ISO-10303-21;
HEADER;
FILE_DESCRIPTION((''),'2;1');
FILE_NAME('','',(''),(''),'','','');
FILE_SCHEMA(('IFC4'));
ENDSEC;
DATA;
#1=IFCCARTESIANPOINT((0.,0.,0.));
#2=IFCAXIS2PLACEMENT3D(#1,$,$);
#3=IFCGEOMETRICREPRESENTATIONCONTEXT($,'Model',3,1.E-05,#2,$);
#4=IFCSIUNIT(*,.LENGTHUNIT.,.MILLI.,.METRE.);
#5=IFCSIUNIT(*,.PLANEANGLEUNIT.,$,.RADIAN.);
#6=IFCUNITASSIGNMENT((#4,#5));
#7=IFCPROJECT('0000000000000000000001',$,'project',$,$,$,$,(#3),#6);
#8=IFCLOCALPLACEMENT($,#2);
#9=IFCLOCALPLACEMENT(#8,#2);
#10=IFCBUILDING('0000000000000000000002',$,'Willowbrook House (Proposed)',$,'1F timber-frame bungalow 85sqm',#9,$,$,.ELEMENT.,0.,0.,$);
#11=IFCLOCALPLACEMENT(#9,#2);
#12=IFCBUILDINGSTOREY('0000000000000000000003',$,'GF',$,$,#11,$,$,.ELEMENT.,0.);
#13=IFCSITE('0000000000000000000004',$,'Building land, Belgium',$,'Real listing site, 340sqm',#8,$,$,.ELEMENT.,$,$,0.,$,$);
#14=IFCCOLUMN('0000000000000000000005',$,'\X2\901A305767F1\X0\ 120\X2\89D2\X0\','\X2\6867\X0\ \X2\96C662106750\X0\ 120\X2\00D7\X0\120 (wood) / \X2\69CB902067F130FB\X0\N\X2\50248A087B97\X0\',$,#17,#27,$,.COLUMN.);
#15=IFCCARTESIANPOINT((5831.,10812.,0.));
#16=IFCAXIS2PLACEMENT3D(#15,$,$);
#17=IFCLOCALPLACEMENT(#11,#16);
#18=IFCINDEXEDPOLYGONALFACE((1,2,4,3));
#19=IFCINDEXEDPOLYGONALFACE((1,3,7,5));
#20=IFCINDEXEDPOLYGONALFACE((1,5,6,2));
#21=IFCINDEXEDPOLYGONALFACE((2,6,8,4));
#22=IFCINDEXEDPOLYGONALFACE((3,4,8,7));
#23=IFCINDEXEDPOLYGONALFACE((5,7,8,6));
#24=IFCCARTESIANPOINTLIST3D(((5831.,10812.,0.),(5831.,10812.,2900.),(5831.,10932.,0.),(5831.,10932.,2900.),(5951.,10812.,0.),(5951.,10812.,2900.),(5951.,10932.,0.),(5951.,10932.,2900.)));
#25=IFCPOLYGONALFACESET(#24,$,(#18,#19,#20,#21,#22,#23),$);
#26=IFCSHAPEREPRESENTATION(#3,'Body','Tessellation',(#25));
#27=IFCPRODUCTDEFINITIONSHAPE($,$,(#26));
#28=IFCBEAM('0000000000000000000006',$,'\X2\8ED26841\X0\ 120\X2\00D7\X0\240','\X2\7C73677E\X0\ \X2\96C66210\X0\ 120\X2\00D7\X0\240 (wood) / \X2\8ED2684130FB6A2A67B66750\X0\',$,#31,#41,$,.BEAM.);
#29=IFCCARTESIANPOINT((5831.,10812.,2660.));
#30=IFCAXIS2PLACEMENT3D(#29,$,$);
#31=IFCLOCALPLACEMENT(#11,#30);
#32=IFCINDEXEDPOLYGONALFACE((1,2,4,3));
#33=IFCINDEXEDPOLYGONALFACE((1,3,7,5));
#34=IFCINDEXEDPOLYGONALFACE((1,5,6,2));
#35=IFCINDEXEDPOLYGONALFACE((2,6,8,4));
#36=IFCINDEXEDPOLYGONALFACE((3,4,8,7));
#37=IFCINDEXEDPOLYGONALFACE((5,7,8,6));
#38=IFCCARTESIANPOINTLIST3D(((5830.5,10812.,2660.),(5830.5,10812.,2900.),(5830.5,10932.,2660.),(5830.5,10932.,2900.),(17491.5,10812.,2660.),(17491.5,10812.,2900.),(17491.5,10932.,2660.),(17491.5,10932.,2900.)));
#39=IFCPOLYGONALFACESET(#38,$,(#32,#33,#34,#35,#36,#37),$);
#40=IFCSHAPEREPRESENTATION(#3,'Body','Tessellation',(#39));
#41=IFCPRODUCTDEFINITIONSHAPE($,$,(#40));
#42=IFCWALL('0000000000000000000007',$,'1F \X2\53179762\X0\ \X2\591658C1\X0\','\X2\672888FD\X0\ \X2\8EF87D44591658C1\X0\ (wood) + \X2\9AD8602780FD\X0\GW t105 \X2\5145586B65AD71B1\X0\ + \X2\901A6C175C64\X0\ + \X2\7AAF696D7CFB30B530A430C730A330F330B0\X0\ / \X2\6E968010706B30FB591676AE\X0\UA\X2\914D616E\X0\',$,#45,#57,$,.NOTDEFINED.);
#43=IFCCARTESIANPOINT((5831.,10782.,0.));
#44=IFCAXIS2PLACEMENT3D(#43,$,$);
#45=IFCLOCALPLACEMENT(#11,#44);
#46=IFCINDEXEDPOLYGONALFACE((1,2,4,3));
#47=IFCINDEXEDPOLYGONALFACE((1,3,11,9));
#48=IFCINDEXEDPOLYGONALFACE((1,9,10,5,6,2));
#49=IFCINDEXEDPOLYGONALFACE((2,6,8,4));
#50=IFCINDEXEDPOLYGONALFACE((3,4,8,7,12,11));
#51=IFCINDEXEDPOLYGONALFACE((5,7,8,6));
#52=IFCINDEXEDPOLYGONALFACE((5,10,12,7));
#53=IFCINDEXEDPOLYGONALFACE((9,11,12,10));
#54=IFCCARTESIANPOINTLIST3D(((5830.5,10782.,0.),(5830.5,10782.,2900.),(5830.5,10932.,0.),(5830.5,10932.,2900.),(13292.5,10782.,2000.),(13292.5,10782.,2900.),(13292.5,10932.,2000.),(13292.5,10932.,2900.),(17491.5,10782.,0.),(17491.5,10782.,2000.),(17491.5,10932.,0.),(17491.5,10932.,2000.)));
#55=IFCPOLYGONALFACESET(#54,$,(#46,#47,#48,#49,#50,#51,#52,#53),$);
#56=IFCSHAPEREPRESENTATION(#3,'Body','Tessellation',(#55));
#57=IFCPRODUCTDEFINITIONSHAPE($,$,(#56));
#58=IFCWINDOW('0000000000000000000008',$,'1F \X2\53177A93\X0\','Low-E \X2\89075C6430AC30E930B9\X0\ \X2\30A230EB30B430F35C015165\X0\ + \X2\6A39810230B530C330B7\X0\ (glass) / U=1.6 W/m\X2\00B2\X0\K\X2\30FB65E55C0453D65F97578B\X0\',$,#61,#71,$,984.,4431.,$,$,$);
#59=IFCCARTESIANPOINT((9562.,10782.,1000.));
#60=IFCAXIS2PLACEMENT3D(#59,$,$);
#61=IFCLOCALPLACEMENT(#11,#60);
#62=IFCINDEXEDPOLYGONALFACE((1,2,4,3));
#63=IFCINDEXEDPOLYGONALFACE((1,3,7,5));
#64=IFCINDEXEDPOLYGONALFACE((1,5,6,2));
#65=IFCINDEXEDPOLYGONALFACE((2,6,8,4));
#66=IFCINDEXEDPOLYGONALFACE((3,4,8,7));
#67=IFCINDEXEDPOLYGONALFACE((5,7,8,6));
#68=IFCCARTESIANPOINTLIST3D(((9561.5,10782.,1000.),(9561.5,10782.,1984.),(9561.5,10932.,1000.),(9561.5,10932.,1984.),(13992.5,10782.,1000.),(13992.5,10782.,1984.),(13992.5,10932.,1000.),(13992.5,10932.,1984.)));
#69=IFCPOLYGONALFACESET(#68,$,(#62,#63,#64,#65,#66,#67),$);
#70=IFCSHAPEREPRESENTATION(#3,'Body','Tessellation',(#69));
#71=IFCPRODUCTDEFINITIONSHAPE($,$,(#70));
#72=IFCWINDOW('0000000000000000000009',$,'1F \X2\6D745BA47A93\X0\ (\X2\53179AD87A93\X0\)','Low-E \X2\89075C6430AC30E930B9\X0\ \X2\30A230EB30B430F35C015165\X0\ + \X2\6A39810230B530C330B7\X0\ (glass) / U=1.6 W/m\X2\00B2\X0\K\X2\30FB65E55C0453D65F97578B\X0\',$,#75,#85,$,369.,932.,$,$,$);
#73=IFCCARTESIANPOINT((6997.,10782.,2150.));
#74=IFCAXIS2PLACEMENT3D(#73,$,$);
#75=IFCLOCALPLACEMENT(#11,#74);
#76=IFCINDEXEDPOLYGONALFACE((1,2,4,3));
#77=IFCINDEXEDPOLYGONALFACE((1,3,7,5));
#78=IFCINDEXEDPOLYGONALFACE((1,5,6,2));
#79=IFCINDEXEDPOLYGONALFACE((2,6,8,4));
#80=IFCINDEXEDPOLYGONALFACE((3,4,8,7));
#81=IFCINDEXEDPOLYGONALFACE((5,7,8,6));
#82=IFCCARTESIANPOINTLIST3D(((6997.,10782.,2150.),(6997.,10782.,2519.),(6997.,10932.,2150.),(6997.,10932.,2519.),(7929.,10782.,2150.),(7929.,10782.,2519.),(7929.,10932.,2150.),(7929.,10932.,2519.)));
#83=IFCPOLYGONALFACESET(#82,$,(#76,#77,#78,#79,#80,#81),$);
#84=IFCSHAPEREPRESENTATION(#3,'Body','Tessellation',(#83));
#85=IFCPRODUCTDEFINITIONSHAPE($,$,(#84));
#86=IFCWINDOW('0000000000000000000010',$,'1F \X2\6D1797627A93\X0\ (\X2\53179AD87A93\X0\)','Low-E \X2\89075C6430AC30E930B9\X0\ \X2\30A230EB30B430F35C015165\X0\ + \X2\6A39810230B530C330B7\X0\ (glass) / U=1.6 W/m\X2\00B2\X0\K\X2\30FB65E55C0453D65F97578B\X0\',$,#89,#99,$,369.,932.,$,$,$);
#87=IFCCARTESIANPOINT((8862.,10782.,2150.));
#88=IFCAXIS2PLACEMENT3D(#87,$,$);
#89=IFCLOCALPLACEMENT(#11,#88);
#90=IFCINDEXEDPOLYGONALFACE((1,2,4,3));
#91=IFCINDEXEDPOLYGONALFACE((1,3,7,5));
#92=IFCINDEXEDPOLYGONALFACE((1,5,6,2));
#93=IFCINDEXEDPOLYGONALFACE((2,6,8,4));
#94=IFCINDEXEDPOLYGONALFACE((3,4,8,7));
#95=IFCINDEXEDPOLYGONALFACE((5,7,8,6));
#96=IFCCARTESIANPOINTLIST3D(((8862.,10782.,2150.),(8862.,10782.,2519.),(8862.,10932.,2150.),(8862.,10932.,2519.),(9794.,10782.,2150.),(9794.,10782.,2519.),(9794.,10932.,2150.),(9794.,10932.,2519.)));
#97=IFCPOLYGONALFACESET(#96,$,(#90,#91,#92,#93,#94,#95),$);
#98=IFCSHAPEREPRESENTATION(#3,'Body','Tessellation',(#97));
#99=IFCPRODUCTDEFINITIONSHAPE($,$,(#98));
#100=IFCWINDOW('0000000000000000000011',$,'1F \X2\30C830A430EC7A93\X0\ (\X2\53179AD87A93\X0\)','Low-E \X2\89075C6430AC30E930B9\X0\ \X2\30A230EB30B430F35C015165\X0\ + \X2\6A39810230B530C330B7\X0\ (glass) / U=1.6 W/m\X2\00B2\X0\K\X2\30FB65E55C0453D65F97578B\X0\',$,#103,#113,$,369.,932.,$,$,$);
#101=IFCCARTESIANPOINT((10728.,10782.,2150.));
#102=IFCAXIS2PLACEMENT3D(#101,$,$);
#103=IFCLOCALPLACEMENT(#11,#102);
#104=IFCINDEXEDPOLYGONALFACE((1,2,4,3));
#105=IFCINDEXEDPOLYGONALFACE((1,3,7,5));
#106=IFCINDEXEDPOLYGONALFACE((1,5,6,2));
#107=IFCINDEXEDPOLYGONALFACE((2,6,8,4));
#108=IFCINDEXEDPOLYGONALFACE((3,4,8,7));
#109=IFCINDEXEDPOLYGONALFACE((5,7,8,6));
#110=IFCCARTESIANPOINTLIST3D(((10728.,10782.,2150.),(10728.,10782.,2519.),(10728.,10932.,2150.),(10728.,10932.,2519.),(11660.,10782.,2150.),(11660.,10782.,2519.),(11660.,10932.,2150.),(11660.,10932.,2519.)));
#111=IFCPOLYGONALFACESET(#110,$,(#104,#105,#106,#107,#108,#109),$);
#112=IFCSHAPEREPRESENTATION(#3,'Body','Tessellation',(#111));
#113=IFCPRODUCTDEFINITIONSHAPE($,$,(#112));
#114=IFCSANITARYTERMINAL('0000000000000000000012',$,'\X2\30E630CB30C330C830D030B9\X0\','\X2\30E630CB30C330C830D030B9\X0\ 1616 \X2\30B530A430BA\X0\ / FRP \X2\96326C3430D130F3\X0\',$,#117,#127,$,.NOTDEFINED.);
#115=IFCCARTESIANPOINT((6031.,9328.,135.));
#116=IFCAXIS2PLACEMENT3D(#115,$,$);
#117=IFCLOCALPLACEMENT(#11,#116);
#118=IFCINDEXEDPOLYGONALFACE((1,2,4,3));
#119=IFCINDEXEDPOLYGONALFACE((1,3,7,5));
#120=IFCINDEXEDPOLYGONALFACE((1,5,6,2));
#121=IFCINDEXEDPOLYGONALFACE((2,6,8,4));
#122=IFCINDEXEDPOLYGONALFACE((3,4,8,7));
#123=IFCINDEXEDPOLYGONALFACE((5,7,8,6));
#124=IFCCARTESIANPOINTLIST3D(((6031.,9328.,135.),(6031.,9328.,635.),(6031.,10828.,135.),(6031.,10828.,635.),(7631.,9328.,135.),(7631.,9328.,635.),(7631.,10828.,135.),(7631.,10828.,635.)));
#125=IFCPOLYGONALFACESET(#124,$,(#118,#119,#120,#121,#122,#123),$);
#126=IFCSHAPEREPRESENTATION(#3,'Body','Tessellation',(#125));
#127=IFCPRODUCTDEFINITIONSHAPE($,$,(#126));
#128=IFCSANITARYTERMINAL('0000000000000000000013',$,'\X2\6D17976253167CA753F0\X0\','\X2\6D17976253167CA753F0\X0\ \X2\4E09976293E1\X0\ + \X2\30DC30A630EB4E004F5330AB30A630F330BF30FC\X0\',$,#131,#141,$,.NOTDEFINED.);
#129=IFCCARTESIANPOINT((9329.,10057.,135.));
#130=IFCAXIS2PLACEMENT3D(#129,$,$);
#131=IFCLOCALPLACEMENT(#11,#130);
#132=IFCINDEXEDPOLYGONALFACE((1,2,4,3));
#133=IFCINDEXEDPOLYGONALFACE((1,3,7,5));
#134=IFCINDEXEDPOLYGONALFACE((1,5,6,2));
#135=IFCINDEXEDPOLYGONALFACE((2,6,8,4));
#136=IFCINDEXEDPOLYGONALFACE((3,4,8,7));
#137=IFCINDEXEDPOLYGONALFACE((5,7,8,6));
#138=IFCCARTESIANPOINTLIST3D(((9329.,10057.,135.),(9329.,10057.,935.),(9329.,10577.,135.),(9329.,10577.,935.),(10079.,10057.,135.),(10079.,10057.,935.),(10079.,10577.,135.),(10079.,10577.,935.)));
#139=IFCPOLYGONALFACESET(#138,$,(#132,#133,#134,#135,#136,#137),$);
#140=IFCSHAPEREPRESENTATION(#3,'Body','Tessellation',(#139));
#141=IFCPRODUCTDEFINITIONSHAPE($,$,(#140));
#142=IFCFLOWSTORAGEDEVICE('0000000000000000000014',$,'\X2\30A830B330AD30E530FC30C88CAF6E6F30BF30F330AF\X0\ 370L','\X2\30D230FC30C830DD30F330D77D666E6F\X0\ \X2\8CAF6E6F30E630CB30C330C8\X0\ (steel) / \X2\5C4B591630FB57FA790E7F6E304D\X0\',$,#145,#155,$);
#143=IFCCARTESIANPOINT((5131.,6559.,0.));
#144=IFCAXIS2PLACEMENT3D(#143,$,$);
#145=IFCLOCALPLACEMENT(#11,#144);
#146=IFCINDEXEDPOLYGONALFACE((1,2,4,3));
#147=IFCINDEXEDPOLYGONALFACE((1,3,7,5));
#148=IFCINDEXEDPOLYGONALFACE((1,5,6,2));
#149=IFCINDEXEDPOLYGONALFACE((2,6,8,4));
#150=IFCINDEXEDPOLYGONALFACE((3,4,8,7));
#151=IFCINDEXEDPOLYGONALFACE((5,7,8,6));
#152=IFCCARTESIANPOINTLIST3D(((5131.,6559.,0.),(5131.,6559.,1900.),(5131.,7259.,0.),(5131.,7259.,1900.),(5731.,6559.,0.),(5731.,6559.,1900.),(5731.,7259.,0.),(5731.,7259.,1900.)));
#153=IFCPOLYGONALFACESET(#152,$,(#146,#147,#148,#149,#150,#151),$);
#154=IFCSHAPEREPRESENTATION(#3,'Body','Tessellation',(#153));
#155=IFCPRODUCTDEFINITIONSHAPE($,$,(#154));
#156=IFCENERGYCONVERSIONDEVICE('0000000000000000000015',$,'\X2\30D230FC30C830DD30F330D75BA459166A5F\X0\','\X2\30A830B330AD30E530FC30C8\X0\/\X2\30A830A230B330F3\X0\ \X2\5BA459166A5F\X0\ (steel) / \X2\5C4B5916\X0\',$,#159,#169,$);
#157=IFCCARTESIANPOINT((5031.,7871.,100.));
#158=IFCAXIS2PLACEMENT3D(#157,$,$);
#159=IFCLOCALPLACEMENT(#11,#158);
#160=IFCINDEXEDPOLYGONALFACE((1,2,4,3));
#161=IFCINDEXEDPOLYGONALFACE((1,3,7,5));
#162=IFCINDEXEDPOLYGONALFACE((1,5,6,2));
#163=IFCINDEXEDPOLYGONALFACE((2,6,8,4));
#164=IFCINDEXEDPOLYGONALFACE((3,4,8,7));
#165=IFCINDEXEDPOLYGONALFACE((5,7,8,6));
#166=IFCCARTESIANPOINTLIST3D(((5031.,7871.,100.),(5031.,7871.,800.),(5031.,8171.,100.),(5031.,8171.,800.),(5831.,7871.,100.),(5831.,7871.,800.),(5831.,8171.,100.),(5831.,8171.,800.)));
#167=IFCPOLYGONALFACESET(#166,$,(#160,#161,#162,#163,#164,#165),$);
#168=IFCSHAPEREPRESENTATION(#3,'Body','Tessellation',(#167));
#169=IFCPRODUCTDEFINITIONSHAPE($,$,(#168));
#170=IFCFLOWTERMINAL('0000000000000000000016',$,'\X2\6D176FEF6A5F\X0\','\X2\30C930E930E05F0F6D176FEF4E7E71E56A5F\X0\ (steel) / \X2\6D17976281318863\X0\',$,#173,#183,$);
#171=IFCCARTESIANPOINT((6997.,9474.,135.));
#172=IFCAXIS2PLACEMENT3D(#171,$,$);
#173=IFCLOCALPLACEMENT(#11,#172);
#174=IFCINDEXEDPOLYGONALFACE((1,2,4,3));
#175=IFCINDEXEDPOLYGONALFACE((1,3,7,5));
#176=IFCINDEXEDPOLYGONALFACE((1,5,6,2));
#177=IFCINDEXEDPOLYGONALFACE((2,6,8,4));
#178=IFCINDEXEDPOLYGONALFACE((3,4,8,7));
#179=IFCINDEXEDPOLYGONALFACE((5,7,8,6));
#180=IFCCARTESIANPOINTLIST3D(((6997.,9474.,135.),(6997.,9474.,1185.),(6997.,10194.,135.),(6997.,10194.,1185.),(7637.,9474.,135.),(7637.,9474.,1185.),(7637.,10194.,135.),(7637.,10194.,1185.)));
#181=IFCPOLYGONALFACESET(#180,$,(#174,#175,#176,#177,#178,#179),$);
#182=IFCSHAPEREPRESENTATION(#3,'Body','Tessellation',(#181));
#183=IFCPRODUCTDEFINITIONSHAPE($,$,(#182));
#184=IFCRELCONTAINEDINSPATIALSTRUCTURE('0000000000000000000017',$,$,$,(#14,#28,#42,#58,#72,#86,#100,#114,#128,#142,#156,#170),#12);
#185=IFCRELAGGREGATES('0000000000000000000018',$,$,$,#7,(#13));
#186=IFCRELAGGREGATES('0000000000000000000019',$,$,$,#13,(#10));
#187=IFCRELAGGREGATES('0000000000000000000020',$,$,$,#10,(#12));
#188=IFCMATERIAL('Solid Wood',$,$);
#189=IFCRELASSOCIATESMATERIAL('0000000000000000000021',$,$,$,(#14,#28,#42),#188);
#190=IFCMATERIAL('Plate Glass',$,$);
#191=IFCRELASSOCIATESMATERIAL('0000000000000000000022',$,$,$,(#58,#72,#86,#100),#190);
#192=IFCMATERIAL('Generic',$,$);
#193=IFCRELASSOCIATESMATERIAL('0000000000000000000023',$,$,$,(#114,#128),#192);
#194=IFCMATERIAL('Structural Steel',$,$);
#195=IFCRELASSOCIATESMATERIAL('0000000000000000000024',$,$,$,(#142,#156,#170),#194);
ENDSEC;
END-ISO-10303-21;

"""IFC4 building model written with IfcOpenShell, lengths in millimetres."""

from ifc_helpers import new_model, si_unit, frame, frame_2d, origin, place, context, project, spatial, rectangle, extrude, material, element, fill, save


model = new_model("IFC4")

# Units and contexts
model_context = context("Model", 3, precision=1e-05, world=origin())
ifc_project = project(units=[si_unit("LENGTHUNIT", "METRE", prefix="MILLI"), si_unit("PLANEANGLEUNIT", "RADIAN")], contexts=[model_context])

# Site, building, storey
site_placement = place(None, origin())
site = spatial("IfcSite", under=ifc_project, at=site_placement, Name="Building land, Belgium", ObjectType="Real listing site, 340sqm", CompositionType="ELEMENT", RefElevation=0.0)
building_placement = place(site_placement, origin())
building = spatial("IfcBuilding", under=site, at=building_placement, Name="Willowbrook House (Proposed)", ObjectType="1F timber-frame bungalow 85sqm", CompositionType="ELEMENT", ElevationOfRefHeight=0.0, ElevationOfTerrain=0.0)
storey_placement = place(building_placement, origin())
storey = spatial("IfcBuildingStorey", under=building, at=storey_placement, Name="GF", CompositionType="ELEMENT", Elevation=0.0)

# Column
ifc_material_1 = material(Name="Solid Wood")
column_1_placement = place(storey_placement, frame((5831.0, 10812.0, 0.0)))
element("IfcColumn", 1, at=column_1_placement, inside=storey, material=ifc_material_1, Name="通し柱 120角", Description="桧 集成材 120×120 (wood) / 構造柱・N値計算", PredefinedType="COLUMN", context=model_context, shape_type="SweptSolid", body=[
    extrude(rectangle(XDim=120.0, YDim=120.0, at=frame_2d((60.0, 60.0))), frame((5831.0, 10812.0, 0.0)), (0.0, 0.0, 1.0), 2900.0),
])

# Beam
beam_1_placement = place(storey_placement, frame((5831.0, 10812.0, 2660.0)))
element("IfcBeam", 2, at=beam_1_placement, inside=storey, material=ifc_material_1, Name="軒桁 120×240", Description="米松 集成 120×240 (wood) / 軒桁・横架材", PredefinedType="BEAM", context=model_context, shape_type="SweptSolid", body=[
    extrude(rectangle(XDim=11661.0, YDim=120.0, at=frame_2d((5830.0, 60.0))), frame((5831.0, 10812.0, 2660.0)), (0.0, 0.0, 1.0), 240.0),
])

# Wall, openings, windows
wall_1_placement = place(storey_placement, frame((5831.0, 10782.0, 0.0)))
wall_1 = element("IfcWall", 3, at=wall_1_placement, inside=storey, material=ifc_material_1, Name="1F 北面 外壁", Description="木製 軸組外壁 (wood) + 高性能GW t105 充填断熱 + 通気層 + 窯業系サイディング / 準耐火・外皮UA配慮", PredefinedType="NOTDEFINED", context=model_context, shape_type="SweptSolid", body=[
    extrude(rectangle(XDim=11661.0, YDim=150.0, at=frame_2d((5830.0, 75.0))), frame((5831.0, 10782.0, 0.0)), (0.0, 0.0, 1.0), 2900.0),
])
opening_1_placement = place(storey_placement, frame((9562.0, 10782.0, 1000.0)))
opening_1 = element("IfcOpeningElement", 4, at=opening_1_placement, cuts=wall_1, PredefinedType="NOTDEFINED", context=model_context, shape_type="SweptSolid", body=[
    extrude(rectangle(XDim=4431.0, YDim=150.0, at=frame_2d((2215.0, 75.0))), frame((9562.0, 10782.0, 1000.0)), (0.0, 0.0, 1.0), 984.0),
])
opening_2_placement = place(storey_placement, frame((6997.0, 10782.0, 2150.0)))
opening_2 = element("IfcOpeningElement", 5, at=opening_2_placement, cuts=wall_1, PredefinedType="NOTDEFINED", context=model_context, shape_type="SweptSolid", body=[
    extrude(rectangle(XDim=932.0, YDim=150.0, at=frame_2d((466.0, 75.0))), frame((6997.0, 10782.0, 2150.0)), (0.0, 0.0, 1.0), 369.0),
])
opening_3_placement = place(storey_placement, frame((8862.0, 10782.0, 2150.0)))
opening_3 = element("IfcOpeningElement", 6, at=opening_3_placement, cuts=wall_1, PredefinedType="NOTDEFINED", context=model_context, shape_type="SweptSolid", body=[
    extrude(rectangle(XDim=932.0, YDim=150.0, at=frame_2d((466.0, 75.0))), frame((8862.0, 10782.0, 2150.0)), (0.0, 0.0, 1.0), 369.0),
])
opening_4_placement = place(storey_placement, frame((10728.0, 10782.0, 2150.0)))
opening_4 = element("IfcOpeningElement", 7, at=opening_4_placement, cuts=wall_1, PredefinedType="NOTDEFINED", context=model_context, shape_type="SweptSolid", body=[
    extrude(rectangle(XDim=932.0, YDim=150.0, at=frame_2d((466.0, 75.0))), frame((10728.0, 10782.0, 2150.0)), (0.0, 0.0, 1.0), 369.0),
])
ifc_material_2 = material(Name="Plate Glass")
window_1_placement = place(storey_placement, frame((9562.0, 10782.0, 1000.0)))
window_1 = element("IfcWindow", 8, at=window_1_placement, inside=storey, material=ifc_material_2, Name="1F 北窓", Description="Low-E 複層ガラス アルゴン封入 + 樹脂サッシ (glass) / U=1.6 W/m²K・日射取得型", OverallHeight=984.0, OverallWidth=4431.0, context=model_context, shape_type="SweptSolid", body=[
    extrude(rectangle(XDim=4431.0, YDim=150.0, at=frame_2d((2215.0, 75.0))), frame((9562.0, 10782.0, 1000.0)), (0.0, 0.0, 1.0), 984.0),
])
fill(opening_1, window_1)
window_2_placement = place(storey_placement, frame((6997.0, 10782.0, 2150.0)))
window_2 = element("IfcWindow", 9, at=window_2_placement, inside=storey, material=ifc_material_2, Name="1F 浴室窓 (北高窓)", Description="Low-E 複層ガラス アルゴン封入 + 樹脂サッシ (glass) / U=1.6 W/m²K・日射取得型", OverallHeight=369.0, OverallWidth=932.0, context=model_context, shape_type="SweptSolid", body=[
    extrude(rectangle(XDim=932.0, YDim=150.0, at=frame_2d((466.0, 75.0))), frame((6997.0, 10782.0, 2150.0)), (0.0, 0.0, 1.0), 369.0),
])
fill(opening_2, window_2)
window_3_placement = place(storey_placement, frame((8862.0, 10782.0, 2150.0)))
window_3 = element("IfcWindow", 10, at=window_3_placement, inside=storey, material=ifc_material_2, Name="1F 洗面窓 (北高窓)", Description="Low-E 複層ガラス アルゴン封入 + 樹脂サッシ (glass) / U=1.6 W/m²K・日射取得型", OverallHeight=369.0, OverallWidth=932.0, context=model_context, shape_type="SweptSolid", body=[
    extrude(rectangle(XDim=932.0, YDim=150.0, at=frame_2d((466.0, 75.0))), frame((8862.0, 10782.0, 2150.0)), (0.0, 0.0, 1.0), 369.0),
])
fill(opening_3, window_3)
window_4_placement = place(storey_placement, frame((10728.0, 10782.0, 2150.0)))
window_4 = element("IfcWindow", 11, at=window_4_placement, inside=storey, material=ifc_material_2, Name="1F トイレ窓 (北高窓)", Description="Low-E 複層ガラス アルゴン封入 + 樹脂サッシ (glass) / U=1.6 W/m²K・日射取得型", OverallHeight=369.0, OverallWidth=932.0, context=model_context, shape_type="SweptSolid", body=[
    extrude(rectangle(XDim=932.0, YDim=150.0, at=frame_2d((466.0, 75.0))), frame((10728.0, 10782.0, 2150.0)), (0.0, 0.0, 1.0), 369.0),
])
fill(opening_4, window_4)

# Sanitary terminals
ifc_material_3 = material(Name="Generic")
sanitary_terminal_1_placement = place(storey_placement, frame((6031.0, 9328.0, 135.0)))
element("IfcSanitaryTerminal", 12, at=sanitary_terminal_1_placement, inside=storey, material=ifc_material_3, Name="ユニットバス", Description="ユニットバス 1616 サイズ / FRP 防水パン", PredefinedType="NOTDEFINED", context=model_context, shape_type="SweptSolid", body=[
    extrude(rectangle(XDim=1600.0, YDim=1500.0, at=frame_2d((800.0, 750.0))), frame((6031.0, 9328.0, 135.0)), (0.0, 0.0, 1.0), 500.0),
])
sanitary_terminal_2_placement = place(storey_placement, frame((9329.0, 10057.0, 135.0)))
element("IfcSanitaryTerminal", 13, at=sanitary_terminal_2_placement, inside=storey, material=ifc_material_3, Name="洗面化粧台", Description="洗面化粧台 三面鏡 + ボウル一体カウンター", PredefinedType="NOTDEFINED", context=model_context, shape_type="SweptSolid", body=[
    extrude(rectangle(XDim=750.0, YDim=520.0, at=frame_2d((375.0, 260.0))), frame((9329.0, 10057.0, 135.0)), (0.0, 0.0, 1.0), 800.0),
])

# Flow storage device
ifc_material_4 = material(Name="Structural Steel")
flow_storage_device_placement = place(storey_placement, frame((5131.0, 6559.0, 0.0)))
element("IfcFlowStorageDevice", 14, at=flow_storage_device_placement, inside=storey, material=ifc_material_4, Name="エコキュート貯湯タンク 370L", Description="ヒートポンプ給湯 貯湯ユニット (steel) / 屋外・基礎置き", context=model_context, shape_type="SweptSolid", body=[
    extrude(rectangle(XDim=600.0, YDim=700.0, at=frame_2d((300.0, 350.0))), frame((5131.0, 6559.0, 0.0)), (0.0, 0.0, 1.0), 1900.0),
])

# Energy conversion device
energy_conversion_device_placement = place(storey_placement, frame((5031.0, 7871.0, 100.0)))
element("IfcEnergyConversionDevice", 15, at=energy_conversion_device_placement, inside=storey, material=ifc_material_4, Name="ヒートポンプ室外機", Description="エコキュート/エアコン 室外機 (steel) / 屋外", context=model_context, shape_type="SweptSolid", body=[
    extrude(rectangle(XDim=800.0, YDim=300.0, at=frame_2d((400.0, 150.0))), frame((5031.0, 7871.0, 100.0)), (0.0, 0.0, 1.0), 700.0),
])

# Flow terminal
flow_terminal_placement = place(storey_placement, frame((6997.0, 9474.0, 135.0)))
element("IfcFlowTerminal", 16, at=flow_terminal_placement, inside=storey, material=ifc_material_4, Name="洗濯機", Description="ドラム式洗濯乾燥機 (steel) / 洗面脱衣", context=model_context, shape_type="SweptSolid", body=[
    extrude(rectangle(XDim=640.0, YDim=720.0, at=frame_2d((320.0, 360.0))), frame((6997.0, 9474.0, 135.0)), (0.0, 0.0, 1.0), 1050.0),
])

save(model, "model.ifc")
